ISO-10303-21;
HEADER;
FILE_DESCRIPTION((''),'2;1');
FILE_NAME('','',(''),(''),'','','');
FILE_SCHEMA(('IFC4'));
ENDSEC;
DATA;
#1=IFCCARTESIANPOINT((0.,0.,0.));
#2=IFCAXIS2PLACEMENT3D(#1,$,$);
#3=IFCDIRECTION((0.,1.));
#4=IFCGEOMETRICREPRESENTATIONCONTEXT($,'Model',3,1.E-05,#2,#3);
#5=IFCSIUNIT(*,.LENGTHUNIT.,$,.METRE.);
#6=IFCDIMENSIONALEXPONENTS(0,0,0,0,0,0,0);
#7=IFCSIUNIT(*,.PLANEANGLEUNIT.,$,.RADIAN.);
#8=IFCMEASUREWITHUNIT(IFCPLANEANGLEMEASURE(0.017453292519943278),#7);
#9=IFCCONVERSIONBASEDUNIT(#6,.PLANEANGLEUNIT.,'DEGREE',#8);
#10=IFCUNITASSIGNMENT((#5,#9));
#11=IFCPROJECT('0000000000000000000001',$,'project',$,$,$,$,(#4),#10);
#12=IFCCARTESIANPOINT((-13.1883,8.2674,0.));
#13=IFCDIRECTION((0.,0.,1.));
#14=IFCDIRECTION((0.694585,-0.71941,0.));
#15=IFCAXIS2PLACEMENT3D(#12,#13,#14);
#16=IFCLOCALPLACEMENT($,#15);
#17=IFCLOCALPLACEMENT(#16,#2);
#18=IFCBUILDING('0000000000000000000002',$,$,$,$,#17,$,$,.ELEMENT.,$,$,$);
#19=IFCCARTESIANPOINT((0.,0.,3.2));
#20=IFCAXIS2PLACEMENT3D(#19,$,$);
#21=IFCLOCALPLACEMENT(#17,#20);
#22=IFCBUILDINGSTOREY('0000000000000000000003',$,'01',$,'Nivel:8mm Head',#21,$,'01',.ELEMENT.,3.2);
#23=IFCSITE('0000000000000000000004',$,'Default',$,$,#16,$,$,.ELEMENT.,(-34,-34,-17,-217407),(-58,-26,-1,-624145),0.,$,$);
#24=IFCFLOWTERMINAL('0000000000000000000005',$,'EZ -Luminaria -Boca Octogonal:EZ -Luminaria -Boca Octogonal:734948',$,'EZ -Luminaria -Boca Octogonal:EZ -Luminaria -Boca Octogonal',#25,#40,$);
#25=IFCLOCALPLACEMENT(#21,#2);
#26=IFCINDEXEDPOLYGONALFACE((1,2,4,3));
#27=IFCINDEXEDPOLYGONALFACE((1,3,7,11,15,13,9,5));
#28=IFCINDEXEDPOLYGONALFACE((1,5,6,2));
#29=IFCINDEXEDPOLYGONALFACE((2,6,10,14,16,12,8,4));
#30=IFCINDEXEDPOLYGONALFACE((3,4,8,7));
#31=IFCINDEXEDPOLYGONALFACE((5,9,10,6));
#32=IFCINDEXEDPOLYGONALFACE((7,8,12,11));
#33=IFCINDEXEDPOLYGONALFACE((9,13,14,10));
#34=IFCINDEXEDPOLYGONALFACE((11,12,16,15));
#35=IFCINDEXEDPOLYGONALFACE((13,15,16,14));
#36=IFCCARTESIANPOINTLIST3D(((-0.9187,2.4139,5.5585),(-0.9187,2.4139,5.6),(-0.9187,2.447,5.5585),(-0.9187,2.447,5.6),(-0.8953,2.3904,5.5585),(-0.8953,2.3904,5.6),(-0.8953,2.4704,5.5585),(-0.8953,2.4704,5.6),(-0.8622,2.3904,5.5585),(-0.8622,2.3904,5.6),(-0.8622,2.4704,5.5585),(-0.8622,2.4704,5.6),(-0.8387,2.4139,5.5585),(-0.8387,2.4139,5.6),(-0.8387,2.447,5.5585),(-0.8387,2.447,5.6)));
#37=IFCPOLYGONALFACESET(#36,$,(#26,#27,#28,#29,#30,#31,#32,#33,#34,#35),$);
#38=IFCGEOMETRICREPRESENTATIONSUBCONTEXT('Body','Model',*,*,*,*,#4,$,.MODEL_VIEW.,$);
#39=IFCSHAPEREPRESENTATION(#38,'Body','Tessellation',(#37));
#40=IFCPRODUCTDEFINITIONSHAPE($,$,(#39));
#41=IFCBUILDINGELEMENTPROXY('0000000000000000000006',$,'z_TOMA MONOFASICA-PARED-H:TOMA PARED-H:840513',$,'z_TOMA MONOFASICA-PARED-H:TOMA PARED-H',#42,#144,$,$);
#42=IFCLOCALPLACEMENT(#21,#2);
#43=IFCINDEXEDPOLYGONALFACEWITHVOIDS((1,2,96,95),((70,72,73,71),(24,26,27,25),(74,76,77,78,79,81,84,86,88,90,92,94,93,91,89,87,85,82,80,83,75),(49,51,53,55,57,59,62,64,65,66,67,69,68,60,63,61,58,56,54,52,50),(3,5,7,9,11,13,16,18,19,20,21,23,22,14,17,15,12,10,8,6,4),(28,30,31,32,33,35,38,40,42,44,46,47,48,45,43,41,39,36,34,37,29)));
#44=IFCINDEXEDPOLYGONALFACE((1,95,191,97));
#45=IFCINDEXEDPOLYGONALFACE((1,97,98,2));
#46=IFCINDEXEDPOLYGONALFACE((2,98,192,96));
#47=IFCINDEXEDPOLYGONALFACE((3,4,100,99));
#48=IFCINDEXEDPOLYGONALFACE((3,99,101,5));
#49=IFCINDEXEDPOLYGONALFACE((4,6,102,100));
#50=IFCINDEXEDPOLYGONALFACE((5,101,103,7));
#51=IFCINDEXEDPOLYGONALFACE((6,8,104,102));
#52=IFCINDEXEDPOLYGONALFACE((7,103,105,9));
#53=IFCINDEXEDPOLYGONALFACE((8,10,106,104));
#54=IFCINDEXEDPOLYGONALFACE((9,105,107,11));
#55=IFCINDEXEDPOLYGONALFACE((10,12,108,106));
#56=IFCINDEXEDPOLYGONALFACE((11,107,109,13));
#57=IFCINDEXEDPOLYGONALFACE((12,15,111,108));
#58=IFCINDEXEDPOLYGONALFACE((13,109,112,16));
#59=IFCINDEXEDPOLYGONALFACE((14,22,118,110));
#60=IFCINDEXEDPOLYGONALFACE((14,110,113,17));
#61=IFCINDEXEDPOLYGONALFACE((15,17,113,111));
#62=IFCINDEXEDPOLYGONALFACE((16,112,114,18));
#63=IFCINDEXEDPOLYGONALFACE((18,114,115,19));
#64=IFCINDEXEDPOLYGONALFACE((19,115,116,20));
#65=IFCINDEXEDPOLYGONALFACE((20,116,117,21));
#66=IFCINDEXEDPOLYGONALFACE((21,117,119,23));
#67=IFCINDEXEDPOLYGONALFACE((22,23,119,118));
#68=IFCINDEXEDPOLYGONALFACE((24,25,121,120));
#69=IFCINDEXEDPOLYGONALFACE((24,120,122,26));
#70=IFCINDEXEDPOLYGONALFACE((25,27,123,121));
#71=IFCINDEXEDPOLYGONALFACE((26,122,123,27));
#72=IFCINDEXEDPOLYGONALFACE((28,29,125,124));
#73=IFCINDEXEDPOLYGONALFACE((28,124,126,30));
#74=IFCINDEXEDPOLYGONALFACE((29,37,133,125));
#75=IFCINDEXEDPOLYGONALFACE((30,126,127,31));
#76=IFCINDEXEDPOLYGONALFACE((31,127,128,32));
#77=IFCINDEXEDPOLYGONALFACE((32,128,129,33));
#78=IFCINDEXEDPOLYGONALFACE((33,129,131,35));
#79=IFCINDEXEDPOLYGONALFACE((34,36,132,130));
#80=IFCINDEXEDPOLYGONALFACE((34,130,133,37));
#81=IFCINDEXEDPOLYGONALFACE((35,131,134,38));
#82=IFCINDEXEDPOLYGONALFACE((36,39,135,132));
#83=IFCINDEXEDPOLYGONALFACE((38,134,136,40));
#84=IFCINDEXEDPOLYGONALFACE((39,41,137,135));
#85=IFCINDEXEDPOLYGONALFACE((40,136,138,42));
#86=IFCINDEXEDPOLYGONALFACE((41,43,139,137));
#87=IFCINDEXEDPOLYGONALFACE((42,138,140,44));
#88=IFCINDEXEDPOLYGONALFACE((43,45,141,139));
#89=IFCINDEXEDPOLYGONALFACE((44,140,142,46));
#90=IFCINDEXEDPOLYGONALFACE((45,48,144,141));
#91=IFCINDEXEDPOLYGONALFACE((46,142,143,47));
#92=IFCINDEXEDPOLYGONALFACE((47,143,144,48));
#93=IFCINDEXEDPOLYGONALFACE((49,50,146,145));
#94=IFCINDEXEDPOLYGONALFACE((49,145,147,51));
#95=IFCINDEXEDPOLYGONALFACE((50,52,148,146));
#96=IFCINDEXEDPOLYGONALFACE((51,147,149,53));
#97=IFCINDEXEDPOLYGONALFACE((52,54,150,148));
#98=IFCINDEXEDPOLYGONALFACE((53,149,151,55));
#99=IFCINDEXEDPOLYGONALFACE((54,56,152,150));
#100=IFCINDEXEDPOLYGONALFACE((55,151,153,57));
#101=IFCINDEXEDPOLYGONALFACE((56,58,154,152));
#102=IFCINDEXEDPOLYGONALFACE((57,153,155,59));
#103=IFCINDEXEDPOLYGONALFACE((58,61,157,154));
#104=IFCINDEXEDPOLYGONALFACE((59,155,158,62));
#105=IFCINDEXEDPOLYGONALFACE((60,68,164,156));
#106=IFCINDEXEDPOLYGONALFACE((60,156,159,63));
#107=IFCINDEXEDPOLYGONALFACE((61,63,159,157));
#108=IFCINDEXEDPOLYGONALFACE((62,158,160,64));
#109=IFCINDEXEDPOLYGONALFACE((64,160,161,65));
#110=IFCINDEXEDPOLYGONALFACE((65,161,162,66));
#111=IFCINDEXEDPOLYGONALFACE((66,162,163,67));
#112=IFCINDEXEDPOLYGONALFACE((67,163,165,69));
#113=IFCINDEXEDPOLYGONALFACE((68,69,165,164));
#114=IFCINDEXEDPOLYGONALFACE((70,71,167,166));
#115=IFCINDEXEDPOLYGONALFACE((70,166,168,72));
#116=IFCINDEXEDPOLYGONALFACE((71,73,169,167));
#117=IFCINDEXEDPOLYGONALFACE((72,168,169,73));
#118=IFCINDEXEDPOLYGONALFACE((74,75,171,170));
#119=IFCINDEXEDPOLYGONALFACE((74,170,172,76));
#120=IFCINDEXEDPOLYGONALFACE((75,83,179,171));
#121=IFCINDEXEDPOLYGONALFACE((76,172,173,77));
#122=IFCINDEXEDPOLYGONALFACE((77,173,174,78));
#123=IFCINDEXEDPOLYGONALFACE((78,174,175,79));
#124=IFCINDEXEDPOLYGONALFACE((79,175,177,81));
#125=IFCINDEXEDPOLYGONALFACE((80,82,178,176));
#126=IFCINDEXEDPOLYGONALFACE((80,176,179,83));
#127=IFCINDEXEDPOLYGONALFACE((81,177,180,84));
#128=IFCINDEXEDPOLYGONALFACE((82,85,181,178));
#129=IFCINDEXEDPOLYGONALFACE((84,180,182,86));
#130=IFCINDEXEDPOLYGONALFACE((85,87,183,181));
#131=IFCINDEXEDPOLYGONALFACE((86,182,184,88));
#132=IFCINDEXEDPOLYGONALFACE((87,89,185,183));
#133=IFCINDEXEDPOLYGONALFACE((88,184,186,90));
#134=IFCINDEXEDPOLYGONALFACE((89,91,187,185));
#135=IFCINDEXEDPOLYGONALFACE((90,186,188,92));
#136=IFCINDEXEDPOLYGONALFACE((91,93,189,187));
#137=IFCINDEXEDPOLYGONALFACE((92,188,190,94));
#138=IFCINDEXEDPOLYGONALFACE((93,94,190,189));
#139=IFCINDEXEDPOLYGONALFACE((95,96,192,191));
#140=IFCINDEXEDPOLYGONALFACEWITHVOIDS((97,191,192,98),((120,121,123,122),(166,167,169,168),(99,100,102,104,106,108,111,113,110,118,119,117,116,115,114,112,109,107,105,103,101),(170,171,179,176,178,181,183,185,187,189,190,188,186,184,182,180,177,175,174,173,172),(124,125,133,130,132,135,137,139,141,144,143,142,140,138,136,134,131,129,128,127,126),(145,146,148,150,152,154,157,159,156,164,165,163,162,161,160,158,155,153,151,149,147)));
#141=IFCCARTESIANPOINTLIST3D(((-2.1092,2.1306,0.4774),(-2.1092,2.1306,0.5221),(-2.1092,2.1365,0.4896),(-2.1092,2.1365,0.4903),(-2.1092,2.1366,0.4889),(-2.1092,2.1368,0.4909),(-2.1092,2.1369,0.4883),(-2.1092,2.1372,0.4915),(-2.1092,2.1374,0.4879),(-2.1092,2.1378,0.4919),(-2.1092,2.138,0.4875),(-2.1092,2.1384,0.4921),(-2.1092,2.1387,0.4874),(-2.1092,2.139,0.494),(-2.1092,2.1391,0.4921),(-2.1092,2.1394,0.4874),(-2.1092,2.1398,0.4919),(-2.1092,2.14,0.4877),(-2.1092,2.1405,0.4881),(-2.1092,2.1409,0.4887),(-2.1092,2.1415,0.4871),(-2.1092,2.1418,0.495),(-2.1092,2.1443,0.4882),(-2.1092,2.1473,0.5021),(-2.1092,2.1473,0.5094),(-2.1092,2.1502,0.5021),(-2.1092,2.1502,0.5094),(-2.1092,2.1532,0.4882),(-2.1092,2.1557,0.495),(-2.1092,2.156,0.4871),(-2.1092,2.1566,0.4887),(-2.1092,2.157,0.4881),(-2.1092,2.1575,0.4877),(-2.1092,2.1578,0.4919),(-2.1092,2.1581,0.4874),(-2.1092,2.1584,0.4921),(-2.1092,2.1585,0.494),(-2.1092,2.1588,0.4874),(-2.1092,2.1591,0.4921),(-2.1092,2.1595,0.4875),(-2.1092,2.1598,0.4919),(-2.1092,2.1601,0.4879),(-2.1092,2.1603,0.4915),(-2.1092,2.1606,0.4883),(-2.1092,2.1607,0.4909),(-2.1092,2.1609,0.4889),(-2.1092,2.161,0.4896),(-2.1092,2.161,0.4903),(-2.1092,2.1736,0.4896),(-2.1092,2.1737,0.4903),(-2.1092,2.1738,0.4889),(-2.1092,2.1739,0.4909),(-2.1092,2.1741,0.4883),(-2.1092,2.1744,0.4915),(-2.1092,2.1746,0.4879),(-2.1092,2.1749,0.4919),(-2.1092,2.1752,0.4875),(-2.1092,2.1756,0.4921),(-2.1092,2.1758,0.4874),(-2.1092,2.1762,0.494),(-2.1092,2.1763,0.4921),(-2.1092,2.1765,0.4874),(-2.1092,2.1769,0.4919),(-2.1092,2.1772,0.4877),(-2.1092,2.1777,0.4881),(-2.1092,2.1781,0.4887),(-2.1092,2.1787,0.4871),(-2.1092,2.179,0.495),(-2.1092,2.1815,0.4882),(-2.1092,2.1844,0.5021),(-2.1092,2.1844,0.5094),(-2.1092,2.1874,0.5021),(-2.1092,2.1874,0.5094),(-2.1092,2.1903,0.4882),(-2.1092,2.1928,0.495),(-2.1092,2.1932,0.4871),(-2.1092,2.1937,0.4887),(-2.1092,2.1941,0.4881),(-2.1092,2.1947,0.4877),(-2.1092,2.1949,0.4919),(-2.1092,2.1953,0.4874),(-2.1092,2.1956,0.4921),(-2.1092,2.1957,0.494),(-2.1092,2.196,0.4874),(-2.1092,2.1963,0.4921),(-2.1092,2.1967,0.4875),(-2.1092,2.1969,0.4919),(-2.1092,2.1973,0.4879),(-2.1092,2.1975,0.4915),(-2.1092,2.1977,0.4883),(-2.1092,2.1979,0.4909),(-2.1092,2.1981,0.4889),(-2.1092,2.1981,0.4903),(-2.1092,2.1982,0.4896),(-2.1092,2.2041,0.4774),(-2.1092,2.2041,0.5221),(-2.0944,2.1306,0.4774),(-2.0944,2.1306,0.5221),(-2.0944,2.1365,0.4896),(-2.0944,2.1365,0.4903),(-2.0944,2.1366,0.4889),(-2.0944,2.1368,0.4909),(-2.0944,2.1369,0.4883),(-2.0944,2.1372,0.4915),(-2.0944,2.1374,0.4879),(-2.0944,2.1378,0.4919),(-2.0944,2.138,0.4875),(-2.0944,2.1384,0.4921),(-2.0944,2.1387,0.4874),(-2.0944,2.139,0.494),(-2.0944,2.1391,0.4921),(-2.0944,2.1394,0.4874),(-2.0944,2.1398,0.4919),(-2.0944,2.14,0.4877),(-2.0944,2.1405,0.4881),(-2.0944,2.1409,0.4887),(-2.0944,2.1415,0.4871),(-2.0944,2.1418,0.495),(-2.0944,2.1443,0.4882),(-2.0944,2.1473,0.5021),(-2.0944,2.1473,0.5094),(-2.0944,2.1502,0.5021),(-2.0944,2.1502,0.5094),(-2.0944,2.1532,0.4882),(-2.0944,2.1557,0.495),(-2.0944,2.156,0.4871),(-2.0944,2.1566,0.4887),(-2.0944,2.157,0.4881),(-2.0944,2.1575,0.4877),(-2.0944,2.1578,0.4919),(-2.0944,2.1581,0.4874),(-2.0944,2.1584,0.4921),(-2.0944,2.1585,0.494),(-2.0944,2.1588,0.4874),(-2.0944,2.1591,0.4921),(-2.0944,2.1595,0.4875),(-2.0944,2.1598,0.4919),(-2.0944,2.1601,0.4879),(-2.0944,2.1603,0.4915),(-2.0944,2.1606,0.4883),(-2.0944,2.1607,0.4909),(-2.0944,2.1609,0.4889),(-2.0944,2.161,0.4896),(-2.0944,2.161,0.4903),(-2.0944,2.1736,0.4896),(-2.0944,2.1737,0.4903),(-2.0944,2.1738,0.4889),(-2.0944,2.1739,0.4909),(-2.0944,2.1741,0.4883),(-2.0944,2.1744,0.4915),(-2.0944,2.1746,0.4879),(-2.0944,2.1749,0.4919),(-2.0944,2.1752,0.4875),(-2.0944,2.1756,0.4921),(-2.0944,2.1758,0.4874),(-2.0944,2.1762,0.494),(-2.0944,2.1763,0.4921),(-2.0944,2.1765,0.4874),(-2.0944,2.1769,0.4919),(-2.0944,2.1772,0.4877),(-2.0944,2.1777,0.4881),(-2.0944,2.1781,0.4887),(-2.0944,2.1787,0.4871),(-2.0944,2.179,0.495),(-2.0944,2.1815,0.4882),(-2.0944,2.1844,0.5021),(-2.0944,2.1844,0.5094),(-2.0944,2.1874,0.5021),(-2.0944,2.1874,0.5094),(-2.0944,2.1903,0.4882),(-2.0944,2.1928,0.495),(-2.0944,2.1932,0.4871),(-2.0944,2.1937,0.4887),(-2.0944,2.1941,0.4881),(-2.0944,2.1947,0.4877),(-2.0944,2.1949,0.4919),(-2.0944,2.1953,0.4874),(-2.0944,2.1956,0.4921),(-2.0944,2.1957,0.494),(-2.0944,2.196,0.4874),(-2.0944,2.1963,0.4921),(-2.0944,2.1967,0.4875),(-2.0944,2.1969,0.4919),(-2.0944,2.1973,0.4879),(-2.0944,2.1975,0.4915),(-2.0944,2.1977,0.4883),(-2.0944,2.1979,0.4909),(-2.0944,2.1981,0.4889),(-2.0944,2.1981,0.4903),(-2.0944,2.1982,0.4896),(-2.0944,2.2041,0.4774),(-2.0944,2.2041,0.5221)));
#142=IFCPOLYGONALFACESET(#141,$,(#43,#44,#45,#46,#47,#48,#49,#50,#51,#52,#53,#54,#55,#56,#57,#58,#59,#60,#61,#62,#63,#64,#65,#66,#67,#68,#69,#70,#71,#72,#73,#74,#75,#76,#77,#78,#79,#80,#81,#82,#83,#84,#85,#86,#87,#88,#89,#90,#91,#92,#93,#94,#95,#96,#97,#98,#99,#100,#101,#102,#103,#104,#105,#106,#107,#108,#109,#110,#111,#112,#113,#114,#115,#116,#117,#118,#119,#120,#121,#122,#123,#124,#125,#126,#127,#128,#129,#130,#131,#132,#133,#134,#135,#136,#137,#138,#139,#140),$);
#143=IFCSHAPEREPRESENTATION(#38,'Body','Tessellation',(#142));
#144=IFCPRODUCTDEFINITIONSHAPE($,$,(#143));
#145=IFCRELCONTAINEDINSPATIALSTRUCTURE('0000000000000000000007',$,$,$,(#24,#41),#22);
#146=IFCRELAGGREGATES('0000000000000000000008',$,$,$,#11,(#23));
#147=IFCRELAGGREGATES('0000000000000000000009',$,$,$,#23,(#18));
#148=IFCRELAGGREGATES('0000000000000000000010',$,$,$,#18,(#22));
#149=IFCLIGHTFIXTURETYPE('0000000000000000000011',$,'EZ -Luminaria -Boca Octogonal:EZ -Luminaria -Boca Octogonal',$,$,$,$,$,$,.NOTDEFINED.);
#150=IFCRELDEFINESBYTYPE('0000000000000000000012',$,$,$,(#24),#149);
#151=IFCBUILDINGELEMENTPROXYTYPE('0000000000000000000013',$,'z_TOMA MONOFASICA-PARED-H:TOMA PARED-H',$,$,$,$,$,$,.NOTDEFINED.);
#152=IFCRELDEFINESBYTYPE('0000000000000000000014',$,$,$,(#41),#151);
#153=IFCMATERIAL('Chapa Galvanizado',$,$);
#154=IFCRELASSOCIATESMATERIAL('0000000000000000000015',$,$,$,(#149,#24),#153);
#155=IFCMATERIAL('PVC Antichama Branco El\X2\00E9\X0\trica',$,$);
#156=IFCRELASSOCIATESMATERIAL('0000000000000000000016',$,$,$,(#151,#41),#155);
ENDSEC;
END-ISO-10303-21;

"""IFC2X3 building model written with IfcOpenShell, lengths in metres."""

from ifc_helpers import new_model, entity, si_unit, converted_unit, direction, frame, frame_2d, origin, place, context, subcontext, project, spatial, polyline, circle_curve, parameter, trimmed, segment, composite_curve, outline, extrude, source, transform, mapped, material, type_object, type_shapes, element, save


model = new_model("IFC2X3")

# Units and contexts
model_context = context("Model", 3, precision=1e-05, world=origin(), true_north=direction((0.0, 1.0)))
body_context = subcontext(model_context, "Body", "Model", "MODEL_VIEW")
ifc_project = project(units=[si_unit("LENGTHUNIT", "METRE"), converted_unit("PLANEANGLEUNIT", "DEGREE", entity("IfcPlaneAngleMeasure", 0.017453292519943278), si_unit("PLANEANGLEUNIT", "RADIAN"), dimensions=[0, 0, 0, 0, 0, 0, 0])], contexts=[model_context])

# Site, building, storey
site_placement = place(None, frame((-13.1883, 8.2674, 0.0), z_axis=(0.0, 0.0, 1.0), x_axis=(0.694585, -0.71941, 0.0)))
site = spatial("IfcSite", under=ifc_project, at=site_placement, Name="Default", CompositionType="ELEMENT", RefLatitude=(-34, -34, -17, -217407), RefLongitude=(-58, -26, -1, -624145), RefElevation=0.0)
building_placement = place(site_placement, origin())
building = spatial("IfcBuilding", under=site, at=building_placement, CompositionType="ELEMENT")
storey_placement = place(building_placement, frame((0.0, 0.0, 3.2)))
storey = spatial("IfcBuildingStorey", under=building, at=storey_placement, Name="01", ObjectType="Nivel:8mm Head", LongName="01", CompositionType="ELEMENT", Elevation=3.2)

# Flow terminal
ifc_material_1 = material(Name="Chapa Galvanizado")
light_fixture_type = type_object("IfcLightFixtureType", Name="EZ -Luminaria -Boca Octogonal:EZ -Luminaria -Boca Octogonal", PredefinedType="NOTDEFINED", material=ifc_material_1)
shared_shape_1 = source(origin(), body_context, "Body", "SweptSolid", [
    extrude(outline(polyline([(-0.0166, -0.04), (0.0166, -0.04), (0.04, -0.0166), (0.04, 0.0166), (0.0166, 0.04), (-0.0166, 0.04), (-0.04, 0.0166), (-0.04, -0.0166), (-0.0166, -0.04)])), frame((0.0, 0.0, -0.0415), z_axis=(0.0, 0.0, 1.0), x_axis=(0.0, -1.0, 0.0)), (0.0, 0.0, 1.0), 0.0415),
])
type_shapes(light_fixture_type, [shared_shape_1])
flow_terminal_placement = place(storey_placement, frame((-0.8787, 2.4304, 5.6)))
element("IfcFlowTerminal", 1, at=flow_terminal_placement, inside=storey, type_object=light_fixture_type, material=ifc_material_1, Name="EZ -Luminaria -Boca Octogonal:EZ -Luminaria -Boca Octogonal:734948", ObjectType="EZ -Luminaria -Boca Octogonal:EZ -Luminaria -Boca Octogonal", context=body_context, shape_type="MappedRepresentation", body=[
    mapped(shared_shape_1, transform((0.0, 0.0, 0.0), scale=1.0)),
])

# Building element proxy
ifc_material_2 = material(Name="PVC Antichama Branco Elétrica")
building_element_proxy_type_1 = type_object("IfcBuildingElementProxyType", Name="z_TOMA MONOFASICA-PARED-H:TOMA PARED-H", PredefinedType="NOTDEFINED", material=ifc_material_2)
shared_shape_2 = source(origin(), body_context, "Body", "SweptSolid", [
    extrude(outline(polyline([(-0.0368, -0.0223), (0.0368, -0.0223), (0.0368, 0.0223), (-0.0368, 0.0223), (-0.0368, -0.0223)]), holes=[composite_curve([segment(polyline([(0.0141, 0.0115), (0.0116, 0.0047)]), True, "CONTINUOUS"), segment(polyline([(0.0116, 0.0047), (0.0088, 0.0057)]), True, "CONTINUOUS"), segment(polyline([(0.0088, 0.0057), (0.0096, 0.0078)]), True, "CONTINUOUS"), segment(trimmed(circle_curve(frame_2d((0.0087, 0.0099), x_axis=(1.0, 0.0)), 0.0024), [parameter(27.118901)], [parameter(292.881099)], True, "PARAMETER"), False, "CONTINUOUS"), segment(polyline([(0.0108, 0.011), (0.0113, 0.0126)]), True, "CONTINUOUS"), segment(polyline([(0.0113, 0.0126), (0.0141, 0.0115)]), True, "CONTINUOUS")], self_intersect=False), composite_curve([segment(polyline([(0.0255, 0.0047), (0.023, 0.0115)]), True, "CONTINUOUS"), segment(polyline([(0.023, 0.0115), (0.0258, 0.0126)]), True, "CONTINUOUS"), segment(polyline([(0.0258, 0.0126), (0.0264, 0.011)]), True, "CONTINUOUS"), segment(trimmed(circle_curve(frame_2d((0.0285, 0.0099), x_axis=(1.0, 0.0)), 0.0024), [parameter(247.118901)], [parameter(152.881099)], True, "PARAMETER"), False, "CONTINUOUS"), segment(polyline([(0.0276, 0.0078), (0.0283, 0.0057)]), True, "CONTINUOUS"), segment(polyline([(0.0283, 0.0057), (0.0255, 0.0047)]), True, "CONTINUOUS")], self_intersect=False), polyline([(0.0201, -0.0024), (0.0201, -0.0097), (0.0171, -0.0097), (0.0171, -0.0024), (0.0201, -0.0024)]), composite_curve([segment(polyline([(-0.0141, 0.0115), (-0.0113, 0.0126)]), True, "CONTINUOUS"), segment(polyline([(-0.0113, 0.0126), (-0.0108, 0.011)]), True, "CONTINUOUS"), segment(trimmed(circle_curve(frame_2d((-0.0087, 0.0099), x_axis=(1.0, 0.0)), 0.0024), [parameter(247.118901)], [parameter(152.881099)], True, "PARAMETER"), False, "CONTINUOUS"), segment(polyline([(-0.0096, 0.0078), (-0.0088, 0.0057)]), True, "CONTINUOUS"), segment(polyline([(-0.0088, 0.0057), (-0.0116, 0.0047)]), True, "CONTINUOUS"), segment(polyline([(-0.0116, 0.0047), (-0.0141, 0.0115)]), True, "CONTINUOUS")], self_intersect=False), composite_curve([segment(polyline([(-0.0255, 0.0047), (-0.0283, 0.0057)]), True, "CONTINUOUS"), segment(polyline([(-0.0283, 0.0057), (-0.0276, 0.0078)]), True, "CONTINUOUS"), segment(trimmed(circle_curve(frame_2d((-0.0285, 0.0099), x_axis=(1.0, 0.0)), 0.0024), [parameter(27.118901)], [parameter(292.881099)], True, "PARAMETER"), False, "CONTINUOUS"), segment(polyline([(-0.0264, 0.011), (-0.0258, 0.0126)]), True, "CONTINUOUS"), segment(polyline([(-0.0258, 0.0126), (-0.023, 0.0115)]), True, "CONTINUOUS"), segment(polyline([(-0.023, 0.0115), (-0.0255, 0.0047)]), True, "CONTINUOUS")], self_intersect=False), polyline([(-0.0201, -0.0024), (-0.0171, -0.0024), (-0.0171, -0.0097), (-0.0201, -0.0097), (-0.0201, -0.0024)])]), frame((0.0, -0.005, 0.0223), z_axis=(0.0, 1.0, 0.0), x_axis=(1.0, 0.0, 0.0)), (0.0, 0.0, 1.0), 0.0148),
])
type_shapes(building_element_proxy_type_1, [shared_shape_2])
for number, where, z_axis, x_axis, name in (
    (2, (-2.0994, 2.1673, 0.4774), (0.0, 0.0, 1.0), (0.0, 1.0, 0.0), "z_TOMA MONOFASICA-PARED-H:TOMA PARED-H:840513"),
):
    element("IfcBuildingElementProxy", number, at=place(storey_placement, frame(where, z_axis=z_axis, x_axis=x_axis)), inside=storey, type_object=building_element_proxy_type_1, material=ifc_material_2, Name=name, ObjectType="z_TOMA MONOFASICA-PARED-H:TOMA PARED-H", context=body_context, shape_type="MappedRepresentation", body=[
        mapped(shared_shape_2, transform((0.0, 0.0, 0.0), scale=1.0)),
    ])

save(model, "model.ifc")
